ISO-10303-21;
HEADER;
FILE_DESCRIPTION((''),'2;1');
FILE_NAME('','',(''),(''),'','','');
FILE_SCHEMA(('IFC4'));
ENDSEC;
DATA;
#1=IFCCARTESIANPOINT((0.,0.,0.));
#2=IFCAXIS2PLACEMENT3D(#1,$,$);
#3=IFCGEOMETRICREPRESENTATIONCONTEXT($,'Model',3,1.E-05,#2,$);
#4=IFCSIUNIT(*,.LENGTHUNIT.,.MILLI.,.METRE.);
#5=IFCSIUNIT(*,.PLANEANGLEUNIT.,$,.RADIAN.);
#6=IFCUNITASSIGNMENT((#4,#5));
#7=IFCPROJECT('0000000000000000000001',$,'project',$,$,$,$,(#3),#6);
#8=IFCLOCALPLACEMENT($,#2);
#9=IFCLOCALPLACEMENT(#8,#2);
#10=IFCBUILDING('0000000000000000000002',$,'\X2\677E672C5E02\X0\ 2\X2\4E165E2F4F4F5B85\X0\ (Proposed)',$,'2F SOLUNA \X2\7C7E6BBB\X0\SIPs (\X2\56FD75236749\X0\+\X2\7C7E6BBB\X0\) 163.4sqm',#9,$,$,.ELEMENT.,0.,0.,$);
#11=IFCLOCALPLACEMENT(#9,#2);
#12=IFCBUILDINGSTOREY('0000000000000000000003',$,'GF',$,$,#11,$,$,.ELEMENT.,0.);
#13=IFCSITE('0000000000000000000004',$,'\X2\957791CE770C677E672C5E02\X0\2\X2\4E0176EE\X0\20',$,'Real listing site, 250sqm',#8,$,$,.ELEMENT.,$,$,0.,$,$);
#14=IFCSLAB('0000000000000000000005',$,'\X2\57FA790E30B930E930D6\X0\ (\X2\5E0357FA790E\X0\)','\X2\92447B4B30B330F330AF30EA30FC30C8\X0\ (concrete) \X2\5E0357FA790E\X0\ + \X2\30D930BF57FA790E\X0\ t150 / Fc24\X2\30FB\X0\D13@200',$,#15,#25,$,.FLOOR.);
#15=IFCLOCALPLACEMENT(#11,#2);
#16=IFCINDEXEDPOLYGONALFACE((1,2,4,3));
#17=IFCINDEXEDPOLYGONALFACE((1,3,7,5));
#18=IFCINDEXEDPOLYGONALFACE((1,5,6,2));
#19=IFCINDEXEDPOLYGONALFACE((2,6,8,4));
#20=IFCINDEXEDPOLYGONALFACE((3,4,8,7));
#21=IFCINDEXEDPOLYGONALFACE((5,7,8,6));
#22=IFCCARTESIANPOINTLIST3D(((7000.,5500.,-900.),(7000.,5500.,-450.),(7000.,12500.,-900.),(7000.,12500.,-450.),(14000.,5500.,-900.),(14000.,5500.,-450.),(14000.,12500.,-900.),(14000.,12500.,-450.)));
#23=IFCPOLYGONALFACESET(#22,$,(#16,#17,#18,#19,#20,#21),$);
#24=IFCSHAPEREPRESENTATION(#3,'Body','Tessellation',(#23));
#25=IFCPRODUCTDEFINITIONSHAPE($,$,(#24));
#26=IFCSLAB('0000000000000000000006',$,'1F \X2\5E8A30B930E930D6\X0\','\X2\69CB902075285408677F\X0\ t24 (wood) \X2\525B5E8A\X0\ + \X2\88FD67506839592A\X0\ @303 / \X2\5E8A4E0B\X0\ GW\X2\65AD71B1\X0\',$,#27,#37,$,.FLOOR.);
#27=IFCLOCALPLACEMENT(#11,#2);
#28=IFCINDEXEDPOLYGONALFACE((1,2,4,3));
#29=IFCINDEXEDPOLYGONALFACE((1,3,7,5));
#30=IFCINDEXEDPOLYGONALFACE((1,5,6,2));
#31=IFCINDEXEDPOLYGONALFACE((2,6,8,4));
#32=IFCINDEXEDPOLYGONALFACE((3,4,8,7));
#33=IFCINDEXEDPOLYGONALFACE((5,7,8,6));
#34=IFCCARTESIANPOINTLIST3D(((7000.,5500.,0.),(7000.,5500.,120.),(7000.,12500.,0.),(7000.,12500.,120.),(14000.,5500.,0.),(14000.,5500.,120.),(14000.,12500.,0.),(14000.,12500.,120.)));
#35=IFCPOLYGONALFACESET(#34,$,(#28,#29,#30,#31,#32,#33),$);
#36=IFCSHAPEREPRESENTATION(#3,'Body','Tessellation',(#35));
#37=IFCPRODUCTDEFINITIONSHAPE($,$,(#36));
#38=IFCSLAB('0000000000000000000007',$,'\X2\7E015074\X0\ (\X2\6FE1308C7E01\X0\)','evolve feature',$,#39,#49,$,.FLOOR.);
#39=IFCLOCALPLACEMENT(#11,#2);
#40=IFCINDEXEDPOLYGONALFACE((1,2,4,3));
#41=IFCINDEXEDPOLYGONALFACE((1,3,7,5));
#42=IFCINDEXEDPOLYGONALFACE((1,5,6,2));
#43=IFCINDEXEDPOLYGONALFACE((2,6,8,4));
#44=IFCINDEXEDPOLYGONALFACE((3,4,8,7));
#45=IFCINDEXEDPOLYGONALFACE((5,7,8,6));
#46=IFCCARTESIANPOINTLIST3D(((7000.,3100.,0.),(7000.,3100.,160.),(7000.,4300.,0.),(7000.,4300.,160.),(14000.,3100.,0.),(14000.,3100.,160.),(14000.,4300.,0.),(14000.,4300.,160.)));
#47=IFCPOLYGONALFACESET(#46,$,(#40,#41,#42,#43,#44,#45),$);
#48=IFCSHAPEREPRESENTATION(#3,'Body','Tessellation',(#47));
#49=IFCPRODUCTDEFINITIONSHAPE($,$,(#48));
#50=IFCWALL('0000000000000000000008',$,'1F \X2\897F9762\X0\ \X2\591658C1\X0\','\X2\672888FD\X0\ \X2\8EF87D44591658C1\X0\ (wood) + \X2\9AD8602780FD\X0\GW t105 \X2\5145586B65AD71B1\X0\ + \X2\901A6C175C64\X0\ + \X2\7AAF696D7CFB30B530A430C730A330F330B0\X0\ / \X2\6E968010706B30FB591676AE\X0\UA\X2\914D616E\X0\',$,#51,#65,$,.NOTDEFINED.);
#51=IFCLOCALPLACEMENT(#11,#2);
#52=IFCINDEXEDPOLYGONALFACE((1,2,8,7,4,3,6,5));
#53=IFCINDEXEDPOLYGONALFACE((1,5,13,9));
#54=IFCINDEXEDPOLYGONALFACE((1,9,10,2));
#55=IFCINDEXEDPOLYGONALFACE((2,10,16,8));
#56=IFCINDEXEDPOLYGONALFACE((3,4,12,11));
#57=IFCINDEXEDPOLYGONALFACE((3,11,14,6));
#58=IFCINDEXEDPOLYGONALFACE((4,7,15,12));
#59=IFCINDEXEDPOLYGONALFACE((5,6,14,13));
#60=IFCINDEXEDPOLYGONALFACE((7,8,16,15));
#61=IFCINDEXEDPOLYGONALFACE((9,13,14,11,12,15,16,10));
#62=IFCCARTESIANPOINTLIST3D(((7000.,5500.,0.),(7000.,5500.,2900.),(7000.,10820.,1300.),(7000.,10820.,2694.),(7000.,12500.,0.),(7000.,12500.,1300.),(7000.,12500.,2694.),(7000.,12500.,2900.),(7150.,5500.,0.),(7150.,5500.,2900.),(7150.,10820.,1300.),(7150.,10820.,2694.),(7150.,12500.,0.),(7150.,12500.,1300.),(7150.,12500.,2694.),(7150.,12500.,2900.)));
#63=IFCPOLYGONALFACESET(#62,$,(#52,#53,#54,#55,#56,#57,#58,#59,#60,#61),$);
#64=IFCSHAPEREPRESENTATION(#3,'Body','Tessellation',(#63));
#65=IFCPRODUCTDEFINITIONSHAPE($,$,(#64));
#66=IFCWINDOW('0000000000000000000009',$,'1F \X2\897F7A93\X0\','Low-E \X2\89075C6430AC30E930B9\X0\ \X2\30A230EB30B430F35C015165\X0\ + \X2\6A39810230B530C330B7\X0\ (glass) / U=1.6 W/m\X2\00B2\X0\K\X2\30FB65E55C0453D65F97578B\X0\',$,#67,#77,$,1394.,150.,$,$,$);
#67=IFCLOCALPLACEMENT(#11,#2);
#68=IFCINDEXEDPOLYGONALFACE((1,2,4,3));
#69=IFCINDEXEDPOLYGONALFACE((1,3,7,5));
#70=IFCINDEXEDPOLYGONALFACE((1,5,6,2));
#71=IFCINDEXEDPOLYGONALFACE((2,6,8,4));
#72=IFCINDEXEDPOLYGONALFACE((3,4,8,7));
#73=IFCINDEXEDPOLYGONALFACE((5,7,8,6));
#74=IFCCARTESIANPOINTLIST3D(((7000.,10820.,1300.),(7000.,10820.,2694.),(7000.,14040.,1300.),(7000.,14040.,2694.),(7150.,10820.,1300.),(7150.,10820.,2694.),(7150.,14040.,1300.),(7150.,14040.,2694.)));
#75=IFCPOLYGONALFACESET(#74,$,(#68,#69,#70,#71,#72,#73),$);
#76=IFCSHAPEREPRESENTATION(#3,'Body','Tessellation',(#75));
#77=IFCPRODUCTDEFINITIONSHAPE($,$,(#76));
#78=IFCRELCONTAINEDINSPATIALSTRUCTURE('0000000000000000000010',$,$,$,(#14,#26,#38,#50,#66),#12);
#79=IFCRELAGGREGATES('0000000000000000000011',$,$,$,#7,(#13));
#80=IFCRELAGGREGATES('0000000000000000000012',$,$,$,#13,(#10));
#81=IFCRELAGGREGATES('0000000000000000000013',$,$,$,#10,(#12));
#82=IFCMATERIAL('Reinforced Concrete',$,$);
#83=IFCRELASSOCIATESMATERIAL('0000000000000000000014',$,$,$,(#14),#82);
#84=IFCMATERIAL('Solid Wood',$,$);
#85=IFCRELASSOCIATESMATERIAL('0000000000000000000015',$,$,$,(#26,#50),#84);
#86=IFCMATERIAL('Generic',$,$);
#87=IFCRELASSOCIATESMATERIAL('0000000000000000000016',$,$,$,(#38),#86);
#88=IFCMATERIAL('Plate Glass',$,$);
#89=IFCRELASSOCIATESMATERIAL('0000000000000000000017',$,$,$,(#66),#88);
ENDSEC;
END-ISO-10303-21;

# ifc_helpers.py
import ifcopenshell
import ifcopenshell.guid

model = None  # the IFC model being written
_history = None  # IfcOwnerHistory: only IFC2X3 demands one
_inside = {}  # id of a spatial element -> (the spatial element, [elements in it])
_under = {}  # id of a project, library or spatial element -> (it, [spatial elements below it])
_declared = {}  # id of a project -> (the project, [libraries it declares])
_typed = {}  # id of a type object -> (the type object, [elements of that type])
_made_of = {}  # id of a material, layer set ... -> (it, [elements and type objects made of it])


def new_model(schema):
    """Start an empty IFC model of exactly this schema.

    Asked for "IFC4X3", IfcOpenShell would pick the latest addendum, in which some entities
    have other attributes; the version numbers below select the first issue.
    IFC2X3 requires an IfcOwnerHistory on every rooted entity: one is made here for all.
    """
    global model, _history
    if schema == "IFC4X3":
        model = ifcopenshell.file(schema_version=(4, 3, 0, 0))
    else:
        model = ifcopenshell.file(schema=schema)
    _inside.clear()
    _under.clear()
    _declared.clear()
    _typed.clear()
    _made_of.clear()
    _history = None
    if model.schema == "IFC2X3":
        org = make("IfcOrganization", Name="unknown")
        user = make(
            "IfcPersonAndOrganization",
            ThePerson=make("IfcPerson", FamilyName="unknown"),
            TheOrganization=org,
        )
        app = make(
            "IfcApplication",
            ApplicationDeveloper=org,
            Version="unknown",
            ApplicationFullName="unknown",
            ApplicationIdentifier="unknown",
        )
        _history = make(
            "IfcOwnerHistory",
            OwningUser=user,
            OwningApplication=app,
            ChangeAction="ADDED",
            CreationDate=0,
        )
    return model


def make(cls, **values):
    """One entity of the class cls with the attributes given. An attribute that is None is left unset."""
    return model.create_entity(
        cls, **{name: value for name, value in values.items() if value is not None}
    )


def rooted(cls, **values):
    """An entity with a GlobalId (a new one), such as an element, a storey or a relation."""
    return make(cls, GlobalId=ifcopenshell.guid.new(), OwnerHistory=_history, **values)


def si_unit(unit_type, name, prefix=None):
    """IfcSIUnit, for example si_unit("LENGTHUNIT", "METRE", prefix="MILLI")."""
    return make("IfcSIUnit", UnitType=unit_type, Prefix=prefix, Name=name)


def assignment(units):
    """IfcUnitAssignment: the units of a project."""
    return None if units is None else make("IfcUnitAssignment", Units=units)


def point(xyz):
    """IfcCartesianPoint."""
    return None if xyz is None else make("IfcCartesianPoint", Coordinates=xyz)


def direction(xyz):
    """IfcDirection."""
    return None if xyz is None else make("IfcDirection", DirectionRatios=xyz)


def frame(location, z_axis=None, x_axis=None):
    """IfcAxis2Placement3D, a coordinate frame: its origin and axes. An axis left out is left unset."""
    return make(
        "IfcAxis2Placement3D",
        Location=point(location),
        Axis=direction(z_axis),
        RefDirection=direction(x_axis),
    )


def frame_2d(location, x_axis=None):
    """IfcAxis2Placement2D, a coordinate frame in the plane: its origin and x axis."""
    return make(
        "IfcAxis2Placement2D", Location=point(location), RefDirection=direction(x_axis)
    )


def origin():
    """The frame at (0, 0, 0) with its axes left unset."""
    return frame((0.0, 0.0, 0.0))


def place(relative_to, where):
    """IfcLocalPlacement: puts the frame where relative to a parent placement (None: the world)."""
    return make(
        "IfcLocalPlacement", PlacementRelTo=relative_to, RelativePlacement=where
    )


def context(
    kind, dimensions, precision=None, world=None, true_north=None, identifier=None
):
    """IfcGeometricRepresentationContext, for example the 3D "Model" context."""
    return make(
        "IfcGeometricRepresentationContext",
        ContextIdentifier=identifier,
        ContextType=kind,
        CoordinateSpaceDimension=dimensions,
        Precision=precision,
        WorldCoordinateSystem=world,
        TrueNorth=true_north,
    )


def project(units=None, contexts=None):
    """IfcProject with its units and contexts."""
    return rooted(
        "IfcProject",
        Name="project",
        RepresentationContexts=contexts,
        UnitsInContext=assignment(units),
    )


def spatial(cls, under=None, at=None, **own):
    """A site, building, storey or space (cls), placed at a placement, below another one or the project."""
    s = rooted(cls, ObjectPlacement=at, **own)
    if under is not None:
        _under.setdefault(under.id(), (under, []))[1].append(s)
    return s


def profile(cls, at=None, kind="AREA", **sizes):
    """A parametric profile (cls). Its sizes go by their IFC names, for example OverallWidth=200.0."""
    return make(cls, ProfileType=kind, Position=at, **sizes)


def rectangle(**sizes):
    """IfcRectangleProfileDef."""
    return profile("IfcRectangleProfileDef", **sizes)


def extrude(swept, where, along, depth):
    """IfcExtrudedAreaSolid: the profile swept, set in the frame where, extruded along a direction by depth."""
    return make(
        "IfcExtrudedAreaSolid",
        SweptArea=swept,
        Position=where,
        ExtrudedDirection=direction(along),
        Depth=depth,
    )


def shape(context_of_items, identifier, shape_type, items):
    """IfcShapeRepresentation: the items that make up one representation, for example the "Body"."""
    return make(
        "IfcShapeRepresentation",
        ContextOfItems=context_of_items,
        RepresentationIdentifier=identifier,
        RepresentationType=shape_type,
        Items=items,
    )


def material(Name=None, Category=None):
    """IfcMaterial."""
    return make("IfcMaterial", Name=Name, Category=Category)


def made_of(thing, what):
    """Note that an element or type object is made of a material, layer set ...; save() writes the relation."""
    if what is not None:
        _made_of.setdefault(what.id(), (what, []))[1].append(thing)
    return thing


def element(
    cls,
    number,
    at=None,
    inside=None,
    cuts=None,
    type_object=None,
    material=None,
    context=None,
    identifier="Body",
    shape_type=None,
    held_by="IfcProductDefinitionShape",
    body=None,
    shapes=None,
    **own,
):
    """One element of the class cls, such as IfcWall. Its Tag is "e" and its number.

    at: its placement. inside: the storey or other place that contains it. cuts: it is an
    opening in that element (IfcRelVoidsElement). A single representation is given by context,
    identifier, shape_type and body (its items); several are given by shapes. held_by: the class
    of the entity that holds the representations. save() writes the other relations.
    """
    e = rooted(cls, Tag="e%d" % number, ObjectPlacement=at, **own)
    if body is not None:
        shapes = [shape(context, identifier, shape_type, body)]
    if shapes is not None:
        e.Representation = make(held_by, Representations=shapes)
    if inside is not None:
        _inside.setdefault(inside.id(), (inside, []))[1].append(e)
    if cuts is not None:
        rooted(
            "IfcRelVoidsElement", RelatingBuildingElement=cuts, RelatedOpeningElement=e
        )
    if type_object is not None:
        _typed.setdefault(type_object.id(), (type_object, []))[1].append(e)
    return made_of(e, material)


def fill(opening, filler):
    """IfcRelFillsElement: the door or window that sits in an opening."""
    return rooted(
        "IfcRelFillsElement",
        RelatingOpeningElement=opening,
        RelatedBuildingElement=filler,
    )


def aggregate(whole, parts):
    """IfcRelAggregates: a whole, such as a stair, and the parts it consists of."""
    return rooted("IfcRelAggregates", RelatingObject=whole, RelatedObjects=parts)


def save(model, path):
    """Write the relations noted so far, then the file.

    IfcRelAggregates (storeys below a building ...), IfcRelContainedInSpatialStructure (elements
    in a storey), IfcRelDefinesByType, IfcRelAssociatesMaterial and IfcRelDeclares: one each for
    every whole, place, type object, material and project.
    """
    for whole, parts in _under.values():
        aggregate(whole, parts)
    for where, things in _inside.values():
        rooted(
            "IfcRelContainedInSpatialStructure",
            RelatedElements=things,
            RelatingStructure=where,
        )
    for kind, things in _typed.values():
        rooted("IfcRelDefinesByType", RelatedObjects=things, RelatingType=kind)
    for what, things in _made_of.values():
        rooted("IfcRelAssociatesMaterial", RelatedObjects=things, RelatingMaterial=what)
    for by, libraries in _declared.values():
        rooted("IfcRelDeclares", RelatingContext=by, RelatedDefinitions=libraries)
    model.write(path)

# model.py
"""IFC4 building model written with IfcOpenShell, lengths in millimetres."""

from ifc_helpers import new_model, si_unit, frame, frame_2d, origin, place, context, project, spatial, rectangle, extrude, material, element, fill, save


model = new_model("IFC4")

# Units and contexts
model_context = context("Model", 3, precision=1e-05, world=origin())
ifc_project = project(units=[si_unit("LENGTHUNIT", "METRE", prefix="MILLI"), si_unit("PLANEANGLEUNIT", "RADIAN")], contexts=[model_context])

# Site, building, storey
site_placement = place(None, origin())
site = spatial("IfcSite", under=ifc_project, at=site_placement, Name="長野県松本市2丁目20", ObjectType="Real listing site, 250sqm", CompositionType="ELEMENT", RefElevation=0.0)
building_placement = place(site_placement, origin())
building = spatial("IfcBuilding", under=site, at=building_placement, Name="松本市 2世帯住宅 (Proposed)", ObjectType="2F SOLUNA 籾殻SIPs (国産杉+籾殻) 163.4sqm", CompositionType="ELEMENT", ElevationOfRefHeight=0.0, ElevationOfTerrain=0.0)
storey_placement = place(building_placement, origin())
storey = spatial("IfcBuildingStorey", under=building, at=storey_placement, Name="GF", CompositionType="ELEMENT", Elevation=0.0)

# Slabs
ifc_material_1 = material(Name="Reinforced Concrete")
slab_1_placement = place(storey_placement, frame((3500.0, 2750.0, -450.0)))
element("IfcSlab", 1, at=slab_1_placement, inside=storey, material=ifc_material_1, Name="基礎スラブ (布基礎)", Description="鉄筋コンクリート (concrete) 布基礎 + ベタ基礎 t150 / Fc24・D13@200", PredefinedType="FLOOR", context=model_context, shape_type="SweptSolid", body=[
    extrude(rectangle(XDim=7000.0, YDim=7000.0, at=frame_2d((3500.0, 3500.0))), frame((3500.0, 2750.0, -450.0)), (0.0, 0.0, 1.0), 450.0),
])
ifc_material_2 = material(Name="Solid Wood")
slab_2_placement = place(storey_placement, frame((3500.0, 2750.0, 0.0)))
element("IfcSlab", 2, at=slab_2_placement, inside=storey, material=ifc_material_2, Name="1F 床スラブ", Description="構造用合板 t24 (wood) 剛床 + 製材根太 @303 / 床下 GW断熱", PredefinedType="FLOOR", context=model_context, shape_type="SweptSolid", body=[
    extrude(rectangle(XDim=7000.0, YDim=7000.0, at=frame_2d((3500.0, 3500.0))), frame((3500.0, 2750.0, 0.0)), (0.0, 0.0, 1.0), 120.0),
])
ifc_material_3 = material(Name="Generic")
slab_3_placement = place(storey_placement, frame((3500.0, 1550.0, 0.0)))
element("IfcSlab", 3, at=slab_3_placement, inside=storey, material=ifc_material_3, Name="縁側 (濡れ縁)", Description="evolve feature", PredefinedType="FLOOR", context=model_context, shape_type="SweptSolid", body=[
    extrude(rectangle(XDim=7000.0, YDim=1200.0, at=frame_2d((3500.0, 600.0))), frame((3500.0, 1550.0, 0.0)), (0.0, 0.0, 1.0), 160.0),
])

# Shared definitions
ifc_material_4 = material(Name="Plate Glass")

# Wall, opening, window
wall_1_placement = place(storey_placement, frame((3500.0, 2750.0, 0.0)))
wall_1 = element("IfcWall", 4, at=wall_1_placement, inside=storey, material=ifc_material_2, Name="1F 西面 外壁", Description="木製 軸組外壁 (wood) + 高性能GW t105 充填断熱 + 通気層 + 窯業系サイディング / 準耐火・外皮UA配慮", PredefinedType="NOTDEFINED", context=model_context, shape_type="SweptSolid", body=[
    extrude(rectangle(XDim=150.0, YDim=7000.0, at=frame_2d((75.0, 3500.0))), frame((3500.0, 2750.0, 0.0)), (0.0, 0.0, 1.0), 2900.0),
])
opening_1_placement = place(storey_placement, frame((3500.0, 5410.0, 650.0)))
opening_1 = element("IfcOpeningElement", 5, at=opening_1_placement, cuts=wall_1, PredefinedType="NOTDEFINED", context=model_context, shape_type="SweptSolid", body=[
    extrude(rectangle(XDim=150.0, YDim=3220.0, at=frame_2d((75.0, 1610.0))), frame((3500.0, 5410.0, 650.0)), (0.0, 0.0, 1.0), 1394.0),
])
window_1_placement = place(storey_placement, frame((3500.0, 5410.0, 650.0)))
window_1 = element("IfcWindow", 6, at=window_1_placement, inside=storey, material=ifc_material_4, Name="1F 西窓", Description="Low-E 複層ガラス アルゴン封入 + 樹脂サッシ (glass) / U=1.6 W/m²K・日射取得型", OverallHeight=1394.0, OverallWidth=150.0, context=model_context, shape_type="SweptSolid", body=[
    extrude(rectangle(XDim=150.0, YDim=3220.0, at=frame_2d((75.0, 1610.0))), frame((3500.0, 5410.0, 650.0)), (0.0, 0.0, 1.0), 1394.0),
])
fill(opening_1, window_1)

save(model, "model.ifc")
